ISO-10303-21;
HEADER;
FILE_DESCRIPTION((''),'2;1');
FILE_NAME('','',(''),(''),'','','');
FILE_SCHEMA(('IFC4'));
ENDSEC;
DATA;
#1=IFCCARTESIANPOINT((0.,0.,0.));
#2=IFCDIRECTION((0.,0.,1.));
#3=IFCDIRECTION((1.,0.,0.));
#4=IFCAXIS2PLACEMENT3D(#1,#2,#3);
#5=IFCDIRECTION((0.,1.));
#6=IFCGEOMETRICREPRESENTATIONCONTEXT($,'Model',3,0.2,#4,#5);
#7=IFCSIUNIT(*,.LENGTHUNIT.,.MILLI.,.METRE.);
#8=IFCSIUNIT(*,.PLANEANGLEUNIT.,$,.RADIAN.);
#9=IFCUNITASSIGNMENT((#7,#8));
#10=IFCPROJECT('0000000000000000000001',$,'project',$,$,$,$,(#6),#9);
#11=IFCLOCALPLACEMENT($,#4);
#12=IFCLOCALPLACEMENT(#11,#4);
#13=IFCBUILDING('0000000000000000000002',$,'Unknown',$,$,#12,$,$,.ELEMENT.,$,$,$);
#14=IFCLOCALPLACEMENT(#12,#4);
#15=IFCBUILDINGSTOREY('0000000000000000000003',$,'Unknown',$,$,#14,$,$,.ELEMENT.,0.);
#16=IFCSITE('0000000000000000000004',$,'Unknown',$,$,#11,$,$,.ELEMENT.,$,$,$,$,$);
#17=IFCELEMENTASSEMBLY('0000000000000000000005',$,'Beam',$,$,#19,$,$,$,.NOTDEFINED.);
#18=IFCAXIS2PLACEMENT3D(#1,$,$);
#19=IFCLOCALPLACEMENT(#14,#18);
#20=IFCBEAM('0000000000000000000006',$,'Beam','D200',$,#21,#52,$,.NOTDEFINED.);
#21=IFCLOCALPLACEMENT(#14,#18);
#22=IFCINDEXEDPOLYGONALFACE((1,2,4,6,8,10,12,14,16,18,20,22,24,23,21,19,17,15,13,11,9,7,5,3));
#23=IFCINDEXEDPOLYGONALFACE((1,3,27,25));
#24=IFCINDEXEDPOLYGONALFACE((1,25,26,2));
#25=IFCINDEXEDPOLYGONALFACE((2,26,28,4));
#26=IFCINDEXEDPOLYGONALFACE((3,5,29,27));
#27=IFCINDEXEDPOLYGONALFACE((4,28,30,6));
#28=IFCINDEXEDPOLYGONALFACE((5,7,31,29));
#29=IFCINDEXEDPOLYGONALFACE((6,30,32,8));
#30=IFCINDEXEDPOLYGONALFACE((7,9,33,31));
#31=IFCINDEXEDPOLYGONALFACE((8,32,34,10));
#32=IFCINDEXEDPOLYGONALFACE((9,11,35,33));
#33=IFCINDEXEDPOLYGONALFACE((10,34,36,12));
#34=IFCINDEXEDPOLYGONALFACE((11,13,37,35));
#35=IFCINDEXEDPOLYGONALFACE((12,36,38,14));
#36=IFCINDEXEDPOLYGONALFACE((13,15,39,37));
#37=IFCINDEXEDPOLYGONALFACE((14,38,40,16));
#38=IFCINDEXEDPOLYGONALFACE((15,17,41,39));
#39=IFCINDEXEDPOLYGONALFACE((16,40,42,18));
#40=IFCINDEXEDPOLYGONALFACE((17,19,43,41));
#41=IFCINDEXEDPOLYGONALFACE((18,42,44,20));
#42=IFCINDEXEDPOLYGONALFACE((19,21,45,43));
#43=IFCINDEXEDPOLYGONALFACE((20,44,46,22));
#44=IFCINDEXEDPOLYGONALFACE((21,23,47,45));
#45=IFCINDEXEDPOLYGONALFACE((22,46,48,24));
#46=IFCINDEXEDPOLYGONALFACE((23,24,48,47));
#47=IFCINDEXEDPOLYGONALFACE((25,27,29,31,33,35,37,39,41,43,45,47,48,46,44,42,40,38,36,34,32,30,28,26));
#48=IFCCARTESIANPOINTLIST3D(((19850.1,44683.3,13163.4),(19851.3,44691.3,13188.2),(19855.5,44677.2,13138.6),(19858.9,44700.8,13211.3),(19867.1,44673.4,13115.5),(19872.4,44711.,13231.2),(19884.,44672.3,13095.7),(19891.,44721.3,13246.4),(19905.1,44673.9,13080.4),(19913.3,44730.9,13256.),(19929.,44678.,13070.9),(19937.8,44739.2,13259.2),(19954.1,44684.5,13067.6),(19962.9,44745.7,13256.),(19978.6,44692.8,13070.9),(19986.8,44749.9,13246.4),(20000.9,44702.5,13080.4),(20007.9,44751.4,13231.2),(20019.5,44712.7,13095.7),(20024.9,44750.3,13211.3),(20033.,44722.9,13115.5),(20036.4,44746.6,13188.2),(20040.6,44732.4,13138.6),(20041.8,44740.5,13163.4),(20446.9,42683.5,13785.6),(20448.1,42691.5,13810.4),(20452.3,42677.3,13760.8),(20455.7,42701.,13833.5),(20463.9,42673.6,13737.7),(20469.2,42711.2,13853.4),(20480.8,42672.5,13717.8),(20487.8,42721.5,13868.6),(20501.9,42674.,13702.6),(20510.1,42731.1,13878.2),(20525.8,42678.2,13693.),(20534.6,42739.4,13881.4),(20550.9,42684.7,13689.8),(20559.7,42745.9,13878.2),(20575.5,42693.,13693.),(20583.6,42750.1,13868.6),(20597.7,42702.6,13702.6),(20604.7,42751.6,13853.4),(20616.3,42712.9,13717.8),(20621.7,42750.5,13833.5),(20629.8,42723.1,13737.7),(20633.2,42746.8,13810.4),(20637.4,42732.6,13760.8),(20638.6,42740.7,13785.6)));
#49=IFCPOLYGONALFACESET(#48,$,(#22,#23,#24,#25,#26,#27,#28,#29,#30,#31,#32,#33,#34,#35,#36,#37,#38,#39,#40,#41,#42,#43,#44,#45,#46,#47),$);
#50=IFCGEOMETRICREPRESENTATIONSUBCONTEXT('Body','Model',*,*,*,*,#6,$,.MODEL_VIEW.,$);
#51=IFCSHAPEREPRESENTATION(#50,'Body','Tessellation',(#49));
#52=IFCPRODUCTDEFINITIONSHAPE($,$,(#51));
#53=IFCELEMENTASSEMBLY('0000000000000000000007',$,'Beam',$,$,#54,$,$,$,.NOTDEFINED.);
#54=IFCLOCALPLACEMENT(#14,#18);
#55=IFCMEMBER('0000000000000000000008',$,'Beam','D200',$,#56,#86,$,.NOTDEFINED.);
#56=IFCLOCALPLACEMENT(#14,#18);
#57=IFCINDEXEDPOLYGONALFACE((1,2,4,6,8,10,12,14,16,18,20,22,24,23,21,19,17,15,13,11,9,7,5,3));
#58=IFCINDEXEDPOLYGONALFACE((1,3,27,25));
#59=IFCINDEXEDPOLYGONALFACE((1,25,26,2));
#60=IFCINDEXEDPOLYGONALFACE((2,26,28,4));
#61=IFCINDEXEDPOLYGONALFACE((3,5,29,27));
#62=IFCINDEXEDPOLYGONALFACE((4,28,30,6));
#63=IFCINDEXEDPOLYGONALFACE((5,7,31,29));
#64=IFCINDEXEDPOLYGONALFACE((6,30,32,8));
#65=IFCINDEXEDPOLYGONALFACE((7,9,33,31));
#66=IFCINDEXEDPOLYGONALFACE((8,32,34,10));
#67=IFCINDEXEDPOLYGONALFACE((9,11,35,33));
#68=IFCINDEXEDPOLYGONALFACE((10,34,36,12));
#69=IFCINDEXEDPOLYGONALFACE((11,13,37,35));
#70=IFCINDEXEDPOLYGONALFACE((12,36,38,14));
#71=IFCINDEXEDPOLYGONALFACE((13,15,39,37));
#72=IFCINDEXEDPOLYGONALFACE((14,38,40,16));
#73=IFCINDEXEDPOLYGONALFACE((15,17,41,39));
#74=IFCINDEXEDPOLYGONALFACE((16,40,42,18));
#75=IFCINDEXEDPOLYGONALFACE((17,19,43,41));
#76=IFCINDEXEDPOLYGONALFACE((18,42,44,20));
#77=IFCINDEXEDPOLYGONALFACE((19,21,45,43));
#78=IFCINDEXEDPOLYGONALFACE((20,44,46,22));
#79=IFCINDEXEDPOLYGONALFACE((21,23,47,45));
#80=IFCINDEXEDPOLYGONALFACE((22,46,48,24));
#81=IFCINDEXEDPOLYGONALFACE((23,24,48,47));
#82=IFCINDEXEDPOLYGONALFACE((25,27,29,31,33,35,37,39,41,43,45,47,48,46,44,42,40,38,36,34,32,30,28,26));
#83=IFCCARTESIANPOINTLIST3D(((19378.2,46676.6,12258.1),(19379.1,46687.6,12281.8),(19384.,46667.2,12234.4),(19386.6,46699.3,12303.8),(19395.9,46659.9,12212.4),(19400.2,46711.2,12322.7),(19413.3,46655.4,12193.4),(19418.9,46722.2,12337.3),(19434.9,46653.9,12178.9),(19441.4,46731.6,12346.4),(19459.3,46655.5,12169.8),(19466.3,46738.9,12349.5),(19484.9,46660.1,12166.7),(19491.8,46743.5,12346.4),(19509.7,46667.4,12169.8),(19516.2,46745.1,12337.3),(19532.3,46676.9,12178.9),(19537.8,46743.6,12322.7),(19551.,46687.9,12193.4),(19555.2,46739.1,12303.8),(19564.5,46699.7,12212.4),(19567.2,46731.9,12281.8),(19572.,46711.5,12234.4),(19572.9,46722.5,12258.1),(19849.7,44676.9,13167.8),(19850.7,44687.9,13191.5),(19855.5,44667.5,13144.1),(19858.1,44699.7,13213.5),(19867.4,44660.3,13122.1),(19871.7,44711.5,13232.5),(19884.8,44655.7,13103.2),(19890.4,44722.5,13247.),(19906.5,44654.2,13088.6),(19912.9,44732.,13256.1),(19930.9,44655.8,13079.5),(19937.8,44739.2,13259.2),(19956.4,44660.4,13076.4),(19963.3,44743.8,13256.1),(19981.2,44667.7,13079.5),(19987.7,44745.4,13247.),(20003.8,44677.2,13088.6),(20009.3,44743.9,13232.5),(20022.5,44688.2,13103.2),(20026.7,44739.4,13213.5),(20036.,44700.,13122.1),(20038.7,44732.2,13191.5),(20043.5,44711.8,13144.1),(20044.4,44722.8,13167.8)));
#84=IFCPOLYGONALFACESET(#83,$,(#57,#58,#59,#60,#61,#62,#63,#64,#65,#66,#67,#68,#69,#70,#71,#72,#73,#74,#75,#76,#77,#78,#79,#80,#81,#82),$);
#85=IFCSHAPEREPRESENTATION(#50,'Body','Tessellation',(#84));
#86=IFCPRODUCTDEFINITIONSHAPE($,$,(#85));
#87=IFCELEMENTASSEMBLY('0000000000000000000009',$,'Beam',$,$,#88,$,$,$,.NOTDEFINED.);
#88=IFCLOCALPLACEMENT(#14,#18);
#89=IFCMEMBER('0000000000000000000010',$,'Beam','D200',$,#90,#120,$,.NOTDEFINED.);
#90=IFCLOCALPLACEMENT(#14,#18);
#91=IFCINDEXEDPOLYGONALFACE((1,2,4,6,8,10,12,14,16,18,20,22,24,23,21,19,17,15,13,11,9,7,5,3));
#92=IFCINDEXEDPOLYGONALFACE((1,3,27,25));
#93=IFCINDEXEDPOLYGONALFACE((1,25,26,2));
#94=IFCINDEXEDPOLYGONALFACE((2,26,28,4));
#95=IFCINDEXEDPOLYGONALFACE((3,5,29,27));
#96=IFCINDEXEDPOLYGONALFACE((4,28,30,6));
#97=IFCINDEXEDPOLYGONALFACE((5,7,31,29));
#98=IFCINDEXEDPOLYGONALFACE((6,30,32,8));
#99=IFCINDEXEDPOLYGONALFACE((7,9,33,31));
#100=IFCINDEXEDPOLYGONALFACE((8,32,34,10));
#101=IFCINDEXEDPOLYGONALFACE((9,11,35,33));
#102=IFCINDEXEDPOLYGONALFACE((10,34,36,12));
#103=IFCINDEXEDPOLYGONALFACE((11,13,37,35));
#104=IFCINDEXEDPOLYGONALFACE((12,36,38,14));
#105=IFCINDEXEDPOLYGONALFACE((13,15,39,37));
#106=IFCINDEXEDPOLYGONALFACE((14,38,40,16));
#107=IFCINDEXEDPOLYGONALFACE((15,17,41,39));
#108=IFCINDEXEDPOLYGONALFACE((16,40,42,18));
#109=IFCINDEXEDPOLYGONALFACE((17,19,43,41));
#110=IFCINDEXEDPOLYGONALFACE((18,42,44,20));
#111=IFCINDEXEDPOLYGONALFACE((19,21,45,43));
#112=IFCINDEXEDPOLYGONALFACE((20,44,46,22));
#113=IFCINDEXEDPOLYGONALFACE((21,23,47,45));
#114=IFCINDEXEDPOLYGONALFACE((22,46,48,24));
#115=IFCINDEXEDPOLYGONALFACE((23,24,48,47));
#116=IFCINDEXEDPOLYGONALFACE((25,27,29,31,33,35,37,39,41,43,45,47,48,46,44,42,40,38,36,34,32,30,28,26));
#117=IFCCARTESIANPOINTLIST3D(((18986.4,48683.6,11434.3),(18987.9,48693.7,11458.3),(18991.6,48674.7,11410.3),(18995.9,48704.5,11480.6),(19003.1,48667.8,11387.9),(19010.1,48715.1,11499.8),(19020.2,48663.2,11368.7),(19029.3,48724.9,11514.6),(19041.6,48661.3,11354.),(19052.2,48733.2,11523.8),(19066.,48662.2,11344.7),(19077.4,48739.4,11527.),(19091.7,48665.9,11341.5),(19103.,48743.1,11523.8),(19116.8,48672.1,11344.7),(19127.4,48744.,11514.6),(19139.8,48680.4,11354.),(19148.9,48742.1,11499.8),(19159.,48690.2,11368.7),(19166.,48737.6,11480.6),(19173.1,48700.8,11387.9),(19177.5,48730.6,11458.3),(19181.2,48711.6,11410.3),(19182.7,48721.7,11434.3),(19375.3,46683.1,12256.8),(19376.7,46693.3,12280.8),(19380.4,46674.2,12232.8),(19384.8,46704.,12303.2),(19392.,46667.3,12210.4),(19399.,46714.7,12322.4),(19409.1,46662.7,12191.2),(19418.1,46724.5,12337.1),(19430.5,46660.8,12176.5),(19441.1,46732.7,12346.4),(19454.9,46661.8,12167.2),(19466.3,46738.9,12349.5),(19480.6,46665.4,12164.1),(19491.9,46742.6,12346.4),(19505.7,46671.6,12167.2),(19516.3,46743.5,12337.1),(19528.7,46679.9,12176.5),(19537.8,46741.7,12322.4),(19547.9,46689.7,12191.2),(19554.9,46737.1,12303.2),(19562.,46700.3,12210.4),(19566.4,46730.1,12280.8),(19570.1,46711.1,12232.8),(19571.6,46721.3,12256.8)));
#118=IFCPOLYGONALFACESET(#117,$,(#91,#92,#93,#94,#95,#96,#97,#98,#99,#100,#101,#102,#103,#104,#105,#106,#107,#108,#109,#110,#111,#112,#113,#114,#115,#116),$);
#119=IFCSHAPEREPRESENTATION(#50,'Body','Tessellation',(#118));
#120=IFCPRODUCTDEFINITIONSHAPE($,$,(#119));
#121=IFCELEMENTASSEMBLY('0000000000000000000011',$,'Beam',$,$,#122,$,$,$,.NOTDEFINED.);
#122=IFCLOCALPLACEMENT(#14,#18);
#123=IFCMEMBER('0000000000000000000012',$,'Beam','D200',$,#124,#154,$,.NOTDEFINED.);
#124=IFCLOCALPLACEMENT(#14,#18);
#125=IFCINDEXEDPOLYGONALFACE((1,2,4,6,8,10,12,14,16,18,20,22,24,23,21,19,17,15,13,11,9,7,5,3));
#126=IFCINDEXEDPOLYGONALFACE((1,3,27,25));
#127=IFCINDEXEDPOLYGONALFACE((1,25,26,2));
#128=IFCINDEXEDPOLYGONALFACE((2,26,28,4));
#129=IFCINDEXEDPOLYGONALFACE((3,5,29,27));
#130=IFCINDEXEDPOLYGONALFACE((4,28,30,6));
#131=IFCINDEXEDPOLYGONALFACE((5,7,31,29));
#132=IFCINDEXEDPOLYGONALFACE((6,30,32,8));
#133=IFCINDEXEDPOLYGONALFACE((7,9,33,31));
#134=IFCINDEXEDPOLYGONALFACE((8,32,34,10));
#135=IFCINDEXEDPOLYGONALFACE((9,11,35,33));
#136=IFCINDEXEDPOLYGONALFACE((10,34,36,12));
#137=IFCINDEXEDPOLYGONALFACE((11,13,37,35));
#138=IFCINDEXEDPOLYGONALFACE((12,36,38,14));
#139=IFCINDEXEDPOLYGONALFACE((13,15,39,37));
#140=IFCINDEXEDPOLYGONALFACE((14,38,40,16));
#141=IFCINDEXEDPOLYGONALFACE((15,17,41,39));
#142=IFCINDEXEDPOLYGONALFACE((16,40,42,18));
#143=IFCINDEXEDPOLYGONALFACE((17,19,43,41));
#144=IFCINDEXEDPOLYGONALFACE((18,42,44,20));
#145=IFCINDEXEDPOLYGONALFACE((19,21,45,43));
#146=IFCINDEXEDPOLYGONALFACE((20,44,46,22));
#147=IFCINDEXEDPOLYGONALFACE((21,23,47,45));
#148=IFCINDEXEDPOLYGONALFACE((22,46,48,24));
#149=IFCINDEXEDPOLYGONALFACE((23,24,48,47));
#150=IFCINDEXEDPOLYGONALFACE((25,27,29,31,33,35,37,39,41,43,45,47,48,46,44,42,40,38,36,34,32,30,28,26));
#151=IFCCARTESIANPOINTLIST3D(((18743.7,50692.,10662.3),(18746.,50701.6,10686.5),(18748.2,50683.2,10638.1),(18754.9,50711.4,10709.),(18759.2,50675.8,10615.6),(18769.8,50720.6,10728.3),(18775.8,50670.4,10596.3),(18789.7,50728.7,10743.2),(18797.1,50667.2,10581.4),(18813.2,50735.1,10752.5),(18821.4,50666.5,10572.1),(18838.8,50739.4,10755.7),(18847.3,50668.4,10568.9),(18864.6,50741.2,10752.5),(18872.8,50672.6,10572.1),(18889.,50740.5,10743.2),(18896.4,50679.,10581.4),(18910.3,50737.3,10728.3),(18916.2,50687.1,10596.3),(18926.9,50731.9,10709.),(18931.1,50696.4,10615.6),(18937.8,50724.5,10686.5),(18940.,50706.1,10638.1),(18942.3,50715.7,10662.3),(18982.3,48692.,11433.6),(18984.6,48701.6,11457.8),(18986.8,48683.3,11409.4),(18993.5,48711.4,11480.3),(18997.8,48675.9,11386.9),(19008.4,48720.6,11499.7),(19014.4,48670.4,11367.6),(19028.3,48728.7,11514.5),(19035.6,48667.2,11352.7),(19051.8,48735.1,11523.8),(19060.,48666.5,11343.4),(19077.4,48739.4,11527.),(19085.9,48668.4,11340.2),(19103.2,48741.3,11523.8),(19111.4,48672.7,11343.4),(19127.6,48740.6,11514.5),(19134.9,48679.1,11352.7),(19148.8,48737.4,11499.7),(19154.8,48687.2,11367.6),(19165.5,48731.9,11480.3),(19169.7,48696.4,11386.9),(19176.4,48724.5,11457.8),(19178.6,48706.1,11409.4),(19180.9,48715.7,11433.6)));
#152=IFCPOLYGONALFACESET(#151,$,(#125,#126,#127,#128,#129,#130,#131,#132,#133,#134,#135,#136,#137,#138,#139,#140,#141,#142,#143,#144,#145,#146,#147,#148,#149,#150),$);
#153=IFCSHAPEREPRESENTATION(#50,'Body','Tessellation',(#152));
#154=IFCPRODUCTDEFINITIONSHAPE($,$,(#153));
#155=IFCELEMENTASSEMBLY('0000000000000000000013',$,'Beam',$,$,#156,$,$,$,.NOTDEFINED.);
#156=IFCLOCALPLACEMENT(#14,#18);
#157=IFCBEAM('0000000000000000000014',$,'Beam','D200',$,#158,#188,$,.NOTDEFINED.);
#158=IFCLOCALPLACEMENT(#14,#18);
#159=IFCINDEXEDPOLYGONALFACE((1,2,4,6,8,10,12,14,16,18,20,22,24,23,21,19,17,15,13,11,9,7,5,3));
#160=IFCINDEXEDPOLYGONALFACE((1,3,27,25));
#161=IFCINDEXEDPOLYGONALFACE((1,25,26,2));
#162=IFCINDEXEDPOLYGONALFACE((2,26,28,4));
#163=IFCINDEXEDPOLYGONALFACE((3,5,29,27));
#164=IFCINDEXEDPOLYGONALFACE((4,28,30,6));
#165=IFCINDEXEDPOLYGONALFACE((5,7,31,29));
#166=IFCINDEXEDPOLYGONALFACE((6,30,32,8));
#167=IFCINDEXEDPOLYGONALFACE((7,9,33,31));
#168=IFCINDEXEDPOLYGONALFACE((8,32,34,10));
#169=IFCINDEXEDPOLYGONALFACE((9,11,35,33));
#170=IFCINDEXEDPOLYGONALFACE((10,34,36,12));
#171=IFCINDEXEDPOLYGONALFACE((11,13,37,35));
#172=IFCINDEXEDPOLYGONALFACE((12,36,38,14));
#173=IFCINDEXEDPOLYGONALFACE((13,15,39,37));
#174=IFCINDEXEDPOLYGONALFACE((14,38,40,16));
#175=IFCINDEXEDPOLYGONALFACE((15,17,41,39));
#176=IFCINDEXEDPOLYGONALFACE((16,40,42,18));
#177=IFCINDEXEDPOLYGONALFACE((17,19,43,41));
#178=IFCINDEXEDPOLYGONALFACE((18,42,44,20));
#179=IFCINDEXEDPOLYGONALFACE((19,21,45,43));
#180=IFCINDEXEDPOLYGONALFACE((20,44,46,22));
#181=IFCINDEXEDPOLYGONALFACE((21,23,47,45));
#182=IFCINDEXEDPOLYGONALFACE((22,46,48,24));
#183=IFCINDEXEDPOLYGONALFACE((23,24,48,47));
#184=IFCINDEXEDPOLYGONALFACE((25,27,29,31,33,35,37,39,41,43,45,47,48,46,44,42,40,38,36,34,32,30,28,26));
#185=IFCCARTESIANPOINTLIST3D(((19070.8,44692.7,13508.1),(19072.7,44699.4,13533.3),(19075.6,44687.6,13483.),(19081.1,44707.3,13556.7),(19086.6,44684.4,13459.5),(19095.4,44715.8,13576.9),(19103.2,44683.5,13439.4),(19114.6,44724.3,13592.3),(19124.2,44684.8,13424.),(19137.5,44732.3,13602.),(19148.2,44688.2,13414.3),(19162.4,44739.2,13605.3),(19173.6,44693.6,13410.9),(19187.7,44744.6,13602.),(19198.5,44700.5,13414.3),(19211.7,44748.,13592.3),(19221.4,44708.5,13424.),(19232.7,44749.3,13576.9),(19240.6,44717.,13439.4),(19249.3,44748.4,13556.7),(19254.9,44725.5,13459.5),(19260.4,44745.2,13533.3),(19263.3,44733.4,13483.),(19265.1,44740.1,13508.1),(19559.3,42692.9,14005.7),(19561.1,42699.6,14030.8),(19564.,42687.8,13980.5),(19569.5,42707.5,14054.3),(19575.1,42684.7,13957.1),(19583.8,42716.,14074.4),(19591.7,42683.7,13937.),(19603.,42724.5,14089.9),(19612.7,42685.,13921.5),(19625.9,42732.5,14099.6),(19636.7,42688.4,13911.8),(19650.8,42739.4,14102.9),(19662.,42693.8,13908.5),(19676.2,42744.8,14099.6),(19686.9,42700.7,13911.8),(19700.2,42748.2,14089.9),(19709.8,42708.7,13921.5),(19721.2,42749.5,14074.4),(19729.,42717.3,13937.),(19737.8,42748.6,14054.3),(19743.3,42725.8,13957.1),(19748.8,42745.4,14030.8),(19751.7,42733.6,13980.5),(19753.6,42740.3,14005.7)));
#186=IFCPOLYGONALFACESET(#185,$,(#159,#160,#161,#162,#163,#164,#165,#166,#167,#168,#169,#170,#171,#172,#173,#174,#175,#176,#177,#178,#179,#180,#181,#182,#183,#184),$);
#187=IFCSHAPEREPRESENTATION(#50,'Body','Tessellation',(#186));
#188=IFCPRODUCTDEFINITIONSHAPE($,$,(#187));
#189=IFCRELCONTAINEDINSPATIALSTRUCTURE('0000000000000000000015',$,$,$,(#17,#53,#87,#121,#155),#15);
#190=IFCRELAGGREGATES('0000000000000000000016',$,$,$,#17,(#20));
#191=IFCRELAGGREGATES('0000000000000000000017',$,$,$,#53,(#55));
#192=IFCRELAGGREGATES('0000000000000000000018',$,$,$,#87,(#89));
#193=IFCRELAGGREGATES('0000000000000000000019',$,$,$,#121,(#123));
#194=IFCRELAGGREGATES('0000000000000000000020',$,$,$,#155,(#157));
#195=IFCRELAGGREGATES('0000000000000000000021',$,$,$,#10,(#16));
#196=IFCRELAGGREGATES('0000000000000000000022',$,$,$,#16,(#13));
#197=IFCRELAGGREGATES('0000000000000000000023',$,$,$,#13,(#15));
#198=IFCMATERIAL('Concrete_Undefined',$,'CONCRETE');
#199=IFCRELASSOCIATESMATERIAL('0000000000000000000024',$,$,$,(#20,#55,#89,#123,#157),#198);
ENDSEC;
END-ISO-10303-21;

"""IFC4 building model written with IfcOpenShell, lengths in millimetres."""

from ifc_helpers import new_model, si_unit, direction, frame, origin_with_axes, place, context, subcontext, project, spatial, line, indexed_curve, outline, extrude, material, element, aggregate, save


model = new_model("IFC4")

# Units and contexts
model_context = context("Model", 3, precision=0.2, world=origin_with_axes(), true_north=direction((0.0, 1.0)))
body_context = subcontext(model_context, "Body", "Model", "MODEL_VIEW")
ifc_project = project(units=[si_unit("LENGTHUNIT", "METRE", prefix="MILLI"), si_unit("PLANEANGLEUNIT", "RADIAN")], contexts=[model_context])

# Site, building, storey
site_placement = place(None, origin_with_axes())
site = spatial("IfcSite", under=ifc_project, at=site_placement, Name="Unknown", CompositionType="ELEMENT")
building_placement = place(site_placement, origin_with_axes())
building = spatial("IfcBuilding", under=site, at=building_placement, Name="Unknown", CompositionType="ELEMENT")
storey_placement = place(building_placement, origin_with_axes())
storey = spatial("IfcBuildingStorey", under=building, at=storey_placement, Name="Unknown", CompositionType="ELEMENT", Elevation=0.0)

# Shared definitions
ifc_material = material(Name="Concrete_Undefined", Category="CONCRETE")

# Element assembly, beam
assembly_1_placement = place(storey_placement, frame((19946.0, 44711.9, 13163.4), z_axis=(-0.958239, -0.285967, 0.0), x_axis=(0.274047, -0.918298, 0.285704)))
assembly_1 = element("IfcElementAssembly", 1, at=assembly_1_placement, inside=storey, Name="Beam", PredefinedType="NOTDEFINED")
beam_1_placement = place(assembly_1_placement, origin_with_axes())
beam_1 = element("IfcBeam", 2, at=beam_1_placement, material=ifc_material, Name="Beam", Description="D200", PredefinedType="NOTDEFINED", context=body_context, shape_type="SolidModel", body=[
    extrude(outline(indexed_curve([(100.0, 0.0), (96.6, 25.9), (86.6, 50.0), (70.7, 70.7), (50.0, 86.6), (25.9, 96.6), (0.0, 100.0), (-25.9, 96.6), (-50.0, 86.6), (-70.7, 70.7), (-86.6, 50.0), (-96.6, 25.9), (-100.0, 0.0), (-96.6, -25.9), (-86.6, -50.0), (-70.7, -70.7), (-50.0, -86.6), (-25.9, -96.6), (0.0, -100.0), (25.9, -96.6), (50.0, -86.6), (70.7, -70.7), (86.6, -50.0), (96.6, -25.9)], segments=[line(1, 2, 3, 4, 5, 6, 7, 8, 9, 10, 11, 12, 13, 14, 15, 16, 17, 18, 19, 20, 21, 22, 23, 24, 1)])), frame((0.0, 0.0, 0.0), z_axis=(-1.0, 0.0, 0.0), x_axis=(0.0, 0.0, 1.0)), (0.0, 0.0, -1.0), 2177.7),
])
aggregate(assembly_1, [beam_1])

# Element assemblies, members
assembly_2_placement = place(storey_placement, frame((19475.6, 46699.5, 12258.1), z_axis=(-0.973309, -0.2295, 0.0), x_axis=(0.209848, -0.889966, 0.404875)))
assembly_2 = element("IfcElementAssembly", 3, at=assembly_2_placement, inside=storey, Name="Beam", PredefinedType="NOTDEFINED")
member_1_placement = place(assembly_2_placement, origin_with_axes())
member_1 = element("IfcMember", 4, at=member_1_placement, material=ifc_material, Name="Beam", Description="D200", PredefinedType="NOTDEFINED", context=body_context, shape_type="SolidModel", body=[
    extrude(outline(indexed_curve([(100.0, 0.0), (96.6, 25.9), (86.6, 50.0), (70.7, 70.7), (50.0, 86.6), (25.9, 96.6), (0.0, 100.0), (-25.9, 96.6), (-50.0, 86.6), (-70.7, 70.7), (-86.6, 50.0), (-96.6, 25.9), (-100.0, 0.0), (-96.6, -25.9), (-86.6, -50.0), (-70.7, -70.7), (-50.0, -86.6), (-25.9, -96.6), (0.0, -100.0), (25.9, -96.6), (50.0, -86.6), (70.7, -70.7), (86.6, -50.0), (96.6, -25.9)], segments=[line(1, 2, 3, 4, 5, 6, 7, 8, 9, 10, 11, 12, 13, 14, 15, 16, 17, 18, 19, 20, 21, 22, 23, 24, 1)])), frame((0.0, 0.0, 0.0), z_axis=(-1.0, 0.0, 0.0), x_axis=(0.0, 0.0, 1.0)), (0.0, 0.0, -1.0), 2246.9),
])
aggregate(assembly_2, [member_1])
assembly_3_placement = place(storey_placement, frame((19084.5, 48702.7, 11434.3), z_axis=(-0.981624, -0.190825, 0.0), x_axis=(0.176955, -0.910278, 0.374274)))
assembly_3 = element("IfcElementAssembly", 5, at=assembly_3_placement, inside=storey, Name="Beam", PredefinedType="NOTDEFINED")
member_2_placement = place(assembly_3_placement, origin_with_axes())
member_2 = element("IfcMember", 6, at=member_2_placement, material=ifc_material, Name="Beam", Description="D200", PredefinedType="NOTDEFINED", context=body_context, shape_type="SolidModel", body=[
    extrude(outline(indexed_curve([(100.0, 0.0), (96.6, 25.9), (86.6, 50.0), (70.7, 70.7), (50.0, 86.6), (25.9, 96.6), (0.0, 100.0), (-25.9, 96.6), (-50.0, 86.6), (-70.7, 70.7), (-86.6, 50.0), (-96.6, 25.9), (-100.0, 0.0), (-96.6, -25.9), (-86.6, -50.0), (-70.7, -70.7), (-50.0, -86.6), (-25.9, -96.6), (0.0, -100.0), (25.9, -96.6), (50.0, -86.6), (70.7, -70.7), (86.6, -50.0), (96.6, -25.9)], segments=[line(1, 2, 3, 4, 5, 6, 7, 8, 9, 10, 11, 12, 13, 14, 15, 16, 17, 18, 19, 20, 21, 22, 23, 24, 1)])), frame((0.0, 0.0, 0.0), z_axis=(-1.0, 0.0, 0.0), x_axis=(0.0, 0.0, 1.0)), (0.0, 0.0, -1.0), 2197.7),
])
aggregate(assembly_3, [member_2])
assembly_4_placement = place(storey_placement, frame((18843.0, 50703.9, 10662.3), z_axis=(-0.992959, -0.118457, 0.0), x_axis=(0.110623, -0.927291, 0.357624)))
assembly_4 = element("IfcElementAssembly", 7, at=assembly_4_placement, inside=storey, Name="Beam", PredefinedType="NOTDEFINED")
member_3_placement = place(assembly_4_placement, origin_with_axes())
member_3 = element("IfcMember", 8, at=member_3_placement, material=ifc_material, Name="Beam", Description="D200", PredefinedType="NOTDEFINED", context=body_context, shape_type="SolidModel", body=[
    extrude(outline(indexed_curve([(100.0, 0.0), (96.6, 25.9), (86.6, 50.0), (70.7, 70.7), (50.0, 86.6), (25.9, 96.6), (0.0, 100.0), (-25.9, 96.6), (-50.0, 86.6), (-70.7, 70.7), (-86.6, 50.0), (-96.6, 25.9), (-100.0, 0.0), (-96.6, -25.9), (-86.6, -50.0), (-70.7, -70.7), (-50.0, -86.6), (-25.9, -96.6), (0.0, -100.0), (25.9, -96.6), (50.0, -86.6), (70.7, -70.7), (86.6, -50.0), (96.6, -25.9)], segments=[line(1, 2, 3, 4, 5, 6, 7, 8, 9, 10, 11, 12, 13, 14, 15, 16, 17, 18, 19, 20, 21, 22, 23, 24, 1)])), frame((0.0, 0.0, 0.0), z_axis=(-1.0, 0.0, 0.0), x_axis=(0.0, 0.0, 1.0)), (0.0, 0.0, -1.0), 2156.8),
])
aggregate(assembly_4, [member_3])

# Element assembly, beam
assembly_5_placement = place(storey_placement, frame((19168.0, 44716.4, 13508.1), z_axis=(-0.971445, -0.237264, 0.0), x_axis=(0.230624, -0.944256, 0.234932)))
assembly_5 = element("IfcElementAssembly", 9, at=assembly_5_placement, inside=storey, Name="Beam", PredefinedType="NOTDEFINED")
beam_2_placement = place(assembly_5_placement, origin_with_axes())
beam_2 = element("IfcBeam", 10, at=beam_2_placement, material=ifc_material, Name="Beam", Description="D200", PredefinedType="NOTDEFINED", context=body_context, shape_type="SolidModel", body=[
    extrude(outline(indexed_curve([(100.0, 0.0), (96.6, 25.9), (86.6, 50.0), (70.7, 70.7), (50.0, 86.6), (25.9, 96.6), (0.0, 100.0), (-25.9, 96.6), (-50.0, 86.6), (-70.7, 70.7), (-86.6, 50.0), (-96.6, 25.9), (-100.0, 0.0), (-96.6, -25.9), (-86.6, -50.0), (-70.7, -70.7), (-50.0, -86.6), (-25.9, -96.6), (0.0, -100.0), (25.9, -96.6), (50.0, -86.6), (70.7, -70.7), (86.6, -50.0), (96.6, -25.9)], segments=[line(1, 2, 3, 4, 5, 6, 7, 8, 9, 10, 11, 12, 13, 14, 15, 16, 17, 18, 19, 20, 21, 22, 23, 24, 1)])), frame((0.0, 0.0, 0.0), z_axis=(-1.0, 0.0, 0.0), x_axis=(0.0, 0.0, 1.0)), (0.0, 0.0, -1.0), 2117.8),
])
aggregate(assembly_5, [beam_2])

save(model, "model.ifc")
